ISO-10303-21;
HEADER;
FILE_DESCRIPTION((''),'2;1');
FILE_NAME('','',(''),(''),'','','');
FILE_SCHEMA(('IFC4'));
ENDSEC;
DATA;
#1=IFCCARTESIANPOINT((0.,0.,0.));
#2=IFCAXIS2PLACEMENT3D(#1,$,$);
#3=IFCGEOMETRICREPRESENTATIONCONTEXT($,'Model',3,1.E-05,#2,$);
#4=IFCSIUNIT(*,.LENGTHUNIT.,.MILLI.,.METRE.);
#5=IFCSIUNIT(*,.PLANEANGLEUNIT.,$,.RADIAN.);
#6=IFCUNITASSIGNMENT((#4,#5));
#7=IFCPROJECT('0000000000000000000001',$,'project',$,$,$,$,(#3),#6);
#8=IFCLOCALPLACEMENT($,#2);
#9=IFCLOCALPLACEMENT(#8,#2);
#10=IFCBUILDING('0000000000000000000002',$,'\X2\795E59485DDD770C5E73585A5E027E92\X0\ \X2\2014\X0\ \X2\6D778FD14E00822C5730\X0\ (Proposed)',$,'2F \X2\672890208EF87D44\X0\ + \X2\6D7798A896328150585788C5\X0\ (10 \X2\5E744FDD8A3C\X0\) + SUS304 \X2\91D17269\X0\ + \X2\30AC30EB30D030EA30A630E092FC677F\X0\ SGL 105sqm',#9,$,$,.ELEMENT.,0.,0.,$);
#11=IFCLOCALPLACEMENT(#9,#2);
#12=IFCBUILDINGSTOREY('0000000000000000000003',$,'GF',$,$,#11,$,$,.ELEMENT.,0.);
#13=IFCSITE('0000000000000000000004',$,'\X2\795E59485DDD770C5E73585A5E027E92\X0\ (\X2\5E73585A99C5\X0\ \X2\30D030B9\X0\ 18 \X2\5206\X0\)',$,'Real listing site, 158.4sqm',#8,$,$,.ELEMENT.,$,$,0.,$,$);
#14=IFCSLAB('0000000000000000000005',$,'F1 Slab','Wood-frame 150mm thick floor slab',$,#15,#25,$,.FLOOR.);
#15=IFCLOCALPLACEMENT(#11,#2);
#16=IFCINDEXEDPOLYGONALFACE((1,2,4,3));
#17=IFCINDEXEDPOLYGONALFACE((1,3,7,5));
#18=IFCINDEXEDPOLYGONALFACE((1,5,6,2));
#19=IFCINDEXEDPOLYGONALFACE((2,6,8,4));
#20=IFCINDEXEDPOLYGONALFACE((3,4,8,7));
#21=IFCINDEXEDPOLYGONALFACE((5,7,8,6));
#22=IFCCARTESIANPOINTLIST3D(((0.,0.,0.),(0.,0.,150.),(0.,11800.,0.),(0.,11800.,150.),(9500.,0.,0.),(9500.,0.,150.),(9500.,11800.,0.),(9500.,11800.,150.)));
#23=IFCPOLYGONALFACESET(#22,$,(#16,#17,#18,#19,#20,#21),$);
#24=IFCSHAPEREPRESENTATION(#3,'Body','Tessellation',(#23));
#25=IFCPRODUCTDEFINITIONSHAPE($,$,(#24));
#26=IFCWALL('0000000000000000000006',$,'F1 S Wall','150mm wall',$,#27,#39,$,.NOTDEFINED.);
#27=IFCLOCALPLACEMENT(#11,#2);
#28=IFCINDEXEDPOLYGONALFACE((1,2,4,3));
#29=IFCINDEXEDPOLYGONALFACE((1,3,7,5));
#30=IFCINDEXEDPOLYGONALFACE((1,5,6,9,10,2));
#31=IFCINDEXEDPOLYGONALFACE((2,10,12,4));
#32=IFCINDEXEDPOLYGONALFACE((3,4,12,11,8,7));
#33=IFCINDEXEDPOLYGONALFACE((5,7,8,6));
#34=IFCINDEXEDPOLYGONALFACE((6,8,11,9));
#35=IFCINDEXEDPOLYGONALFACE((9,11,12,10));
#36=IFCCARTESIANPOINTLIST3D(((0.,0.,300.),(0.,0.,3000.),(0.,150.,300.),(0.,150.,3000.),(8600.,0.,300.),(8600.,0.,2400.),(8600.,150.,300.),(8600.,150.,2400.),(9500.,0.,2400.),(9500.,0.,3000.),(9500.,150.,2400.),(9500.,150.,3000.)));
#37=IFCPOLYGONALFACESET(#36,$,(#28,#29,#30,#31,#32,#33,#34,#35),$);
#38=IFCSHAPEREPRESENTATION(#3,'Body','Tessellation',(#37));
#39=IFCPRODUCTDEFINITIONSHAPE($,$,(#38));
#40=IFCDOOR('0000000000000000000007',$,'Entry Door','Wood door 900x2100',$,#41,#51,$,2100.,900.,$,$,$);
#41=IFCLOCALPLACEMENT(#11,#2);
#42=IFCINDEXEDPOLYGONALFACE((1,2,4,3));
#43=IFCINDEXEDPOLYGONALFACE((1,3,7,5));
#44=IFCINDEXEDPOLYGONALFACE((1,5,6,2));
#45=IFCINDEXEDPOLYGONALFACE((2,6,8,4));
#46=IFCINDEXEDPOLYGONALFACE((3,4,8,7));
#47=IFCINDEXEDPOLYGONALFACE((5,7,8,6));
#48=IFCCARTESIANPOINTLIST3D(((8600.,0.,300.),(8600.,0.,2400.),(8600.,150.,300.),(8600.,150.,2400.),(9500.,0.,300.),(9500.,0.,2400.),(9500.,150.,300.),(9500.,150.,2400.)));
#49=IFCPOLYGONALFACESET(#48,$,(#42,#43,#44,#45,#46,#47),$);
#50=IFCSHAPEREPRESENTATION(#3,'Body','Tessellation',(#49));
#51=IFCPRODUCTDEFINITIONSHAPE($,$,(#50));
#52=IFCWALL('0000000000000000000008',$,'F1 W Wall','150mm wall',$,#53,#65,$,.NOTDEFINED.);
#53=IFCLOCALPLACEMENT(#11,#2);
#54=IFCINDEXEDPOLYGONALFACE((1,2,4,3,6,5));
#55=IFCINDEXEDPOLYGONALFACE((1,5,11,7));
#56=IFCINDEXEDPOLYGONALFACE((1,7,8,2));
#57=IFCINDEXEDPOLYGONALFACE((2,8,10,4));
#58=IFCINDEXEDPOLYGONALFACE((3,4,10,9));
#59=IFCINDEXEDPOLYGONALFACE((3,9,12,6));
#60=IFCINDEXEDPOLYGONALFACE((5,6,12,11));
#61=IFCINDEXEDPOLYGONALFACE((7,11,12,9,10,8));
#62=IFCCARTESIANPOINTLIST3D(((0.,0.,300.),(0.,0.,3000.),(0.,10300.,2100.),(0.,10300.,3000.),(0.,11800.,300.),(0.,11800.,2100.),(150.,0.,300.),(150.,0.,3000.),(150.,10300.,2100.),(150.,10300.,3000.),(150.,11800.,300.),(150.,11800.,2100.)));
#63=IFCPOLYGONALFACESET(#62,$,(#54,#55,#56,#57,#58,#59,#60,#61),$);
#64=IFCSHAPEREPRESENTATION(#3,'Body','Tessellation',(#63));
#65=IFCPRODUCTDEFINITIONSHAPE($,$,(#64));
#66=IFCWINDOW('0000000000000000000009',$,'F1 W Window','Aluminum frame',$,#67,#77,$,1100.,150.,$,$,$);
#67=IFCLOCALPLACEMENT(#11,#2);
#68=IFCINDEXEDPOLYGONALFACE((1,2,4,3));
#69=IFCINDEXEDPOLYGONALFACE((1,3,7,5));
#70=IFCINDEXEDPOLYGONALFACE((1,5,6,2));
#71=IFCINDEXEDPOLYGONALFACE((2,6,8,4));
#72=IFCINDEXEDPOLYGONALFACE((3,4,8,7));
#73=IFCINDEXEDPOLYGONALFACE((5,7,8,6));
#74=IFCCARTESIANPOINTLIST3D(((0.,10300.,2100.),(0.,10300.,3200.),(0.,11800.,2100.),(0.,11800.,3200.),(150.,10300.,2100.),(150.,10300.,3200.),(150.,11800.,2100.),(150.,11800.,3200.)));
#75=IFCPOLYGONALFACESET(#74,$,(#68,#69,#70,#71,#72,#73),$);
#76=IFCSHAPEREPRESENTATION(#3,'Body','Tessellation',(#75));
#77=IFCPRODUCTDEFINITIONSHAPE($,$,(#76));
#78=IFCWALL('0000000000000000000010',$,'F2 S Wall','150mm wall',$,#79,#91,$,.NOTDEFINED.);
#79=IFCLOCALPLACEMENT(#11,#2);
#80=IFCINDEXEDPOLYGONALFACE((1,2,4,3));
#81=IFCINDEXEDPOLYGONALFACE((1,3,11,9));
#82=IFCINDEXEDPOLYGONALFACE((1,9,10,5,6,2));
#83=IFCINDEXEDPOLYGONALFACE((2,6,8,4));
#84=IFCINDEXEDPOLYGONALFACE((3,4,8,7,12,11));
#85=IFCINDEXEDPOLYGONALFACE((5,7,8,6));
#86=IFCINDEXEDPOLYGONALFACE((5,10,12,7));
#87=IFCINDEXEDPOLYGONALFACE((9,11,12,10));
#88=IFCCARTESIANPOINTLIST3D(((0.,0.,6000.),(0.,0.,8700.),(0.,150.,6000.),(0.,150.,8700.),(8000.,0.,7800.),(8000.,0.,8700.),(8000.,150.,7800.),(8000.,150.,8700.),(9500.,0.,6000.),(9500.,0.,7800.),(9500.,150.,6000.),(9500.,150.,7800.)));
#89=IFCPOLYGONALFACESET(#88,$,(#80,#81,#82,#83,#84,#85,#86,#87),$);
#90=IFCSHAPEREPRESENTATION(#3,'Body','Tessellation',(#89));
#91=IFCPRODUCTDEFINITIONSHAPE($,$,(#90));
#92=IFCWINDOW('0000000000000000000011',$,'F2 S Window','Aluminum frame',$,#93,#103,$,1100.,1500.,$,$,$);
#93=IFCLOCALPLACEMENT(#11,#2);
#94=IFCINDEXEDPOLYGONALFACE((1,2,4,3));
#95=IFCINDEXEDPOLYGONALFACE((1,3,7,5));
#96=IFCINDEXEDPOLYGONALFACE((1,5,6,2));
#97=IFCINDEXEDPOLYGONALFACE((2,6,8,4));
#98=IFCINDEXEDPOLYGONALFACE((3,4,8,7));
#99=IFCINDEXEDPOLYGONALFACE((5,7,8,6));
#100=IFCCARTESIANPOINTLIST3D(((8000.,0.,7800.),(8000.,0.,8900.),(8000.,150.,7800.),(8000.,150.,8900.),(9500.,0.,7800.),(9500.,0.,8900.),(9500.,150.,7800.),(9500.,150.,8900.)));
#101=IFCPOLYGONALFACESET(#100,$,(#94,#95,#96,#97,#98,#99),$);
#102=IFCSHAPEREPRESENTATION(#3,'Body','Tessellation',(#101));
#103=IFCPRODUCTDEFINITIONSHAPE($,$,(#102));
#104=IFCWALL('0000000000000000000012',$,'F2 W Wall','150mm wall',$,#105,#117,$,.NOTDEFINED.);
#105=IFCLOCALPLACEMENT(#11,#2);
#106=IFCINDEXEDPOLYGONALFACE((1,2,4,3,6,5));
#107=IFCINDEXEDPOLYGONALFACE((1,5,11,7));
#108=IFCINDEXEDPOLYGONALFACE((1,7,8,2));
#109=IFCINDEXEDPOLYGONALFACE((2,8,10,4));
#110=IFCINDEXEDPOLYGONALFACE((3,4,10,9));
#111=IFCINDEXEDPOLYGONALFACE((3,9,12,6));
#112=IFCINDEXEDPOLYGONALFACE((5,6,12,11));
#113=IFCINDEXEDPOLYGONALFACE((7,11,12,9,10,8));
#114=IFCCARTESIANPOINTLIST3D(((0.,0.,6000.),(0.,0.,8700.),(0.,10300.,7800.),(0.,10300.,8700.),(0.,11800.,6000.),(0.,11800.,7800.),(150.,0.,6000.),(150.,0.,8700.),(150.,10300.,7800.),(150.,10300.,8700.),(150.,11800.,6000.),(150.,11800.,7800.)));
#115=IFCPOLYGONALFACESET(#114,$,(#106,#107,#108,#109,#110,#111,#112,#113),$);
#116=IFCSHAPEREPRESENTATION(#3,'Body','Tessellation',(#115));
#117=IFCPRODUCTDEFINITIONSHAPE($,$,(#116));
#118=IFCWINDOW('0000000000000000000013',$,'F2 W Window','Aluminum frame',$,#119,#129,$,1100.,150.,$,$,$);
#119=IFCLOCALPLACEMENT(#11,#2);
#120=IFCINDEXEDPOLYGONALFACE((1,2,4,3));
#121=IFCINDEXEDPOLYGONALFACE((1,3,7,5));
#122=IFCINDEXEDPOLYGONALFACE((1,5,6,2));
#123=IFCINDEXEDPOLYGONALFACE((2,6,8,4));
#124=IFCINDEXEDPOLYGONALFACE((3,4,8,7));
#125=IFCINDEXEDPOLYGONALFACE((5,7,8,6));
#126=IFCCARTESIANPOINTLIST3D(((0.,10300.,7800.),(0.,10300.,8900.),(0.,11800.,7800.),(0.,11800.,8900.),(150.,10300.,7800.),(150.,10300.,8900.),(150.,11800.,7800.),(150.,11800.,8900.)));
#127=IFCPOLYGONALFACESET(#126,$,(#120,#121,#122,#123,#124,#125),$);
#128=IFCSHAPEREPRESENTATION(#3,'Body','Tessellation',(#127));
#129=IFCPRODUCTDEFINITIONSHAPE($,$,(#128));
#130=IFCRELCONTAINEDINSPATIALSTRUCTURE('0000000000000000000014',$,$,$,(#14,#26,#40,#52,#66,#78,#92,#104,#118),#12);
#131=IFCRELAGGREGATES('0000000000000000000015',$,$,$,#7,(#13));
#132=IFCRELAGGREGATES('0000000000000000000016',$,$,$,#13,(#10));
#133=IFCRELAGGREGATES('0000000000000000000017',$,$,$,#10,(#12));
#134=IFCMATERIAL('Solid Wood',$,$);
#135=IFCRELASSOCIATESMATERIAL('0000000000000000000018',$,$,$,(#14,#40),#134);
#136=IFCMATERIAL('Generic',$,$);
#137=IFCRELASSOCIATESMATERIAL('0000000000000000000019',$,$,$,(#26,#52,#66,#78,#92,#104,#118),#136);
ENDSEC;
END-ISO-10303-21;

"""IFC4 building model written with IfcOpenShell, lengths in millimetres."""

from ifc_helpers import new_model, si_unit, frame, frame_2d, origin, place, context, project, spatial, rectangle, extrude, material, element, fill, save


model = new_model("IFC4")

# Units and contexts
model_context = context("Model", 3, precision=1e-05, world=origin())
ifc_project = project(units=[si_unit("LENGTHUNIT", "METRE", prefix="MILLI"), si_unit("PLANEANGLEUNIT", "RADIAN")], contexts=[model_context])

# Site, building, storey
site_placement = place(None, origin())
site = spatial("IfcSite", under=ifc_project, at=site_placement, Name="神奈川県平塚市纒 (平塚駅 バス 18 分)", ObjectType="Real listing site, 158.4sqm", CompositionType="ELEMENT", RefElevation=0.0)
building_placement = place(site_placement, origin())
building = spatial("IfcBuilding", under=site, at=building_placement, Name="神奈川県平塚市纒 — 海近一般地 (Proposed)", ObjectType="2F 木造軸組 + 海風防腐塗装 (10 年保証) + SUS304 金物 + ガルバリウム鋼板 SGL 105sqm", CompositionType="ELEMENT", ElevationOfRefHeight=0.0, ElevationOfTerrain=0.0)
storey_placement = place(building_placement, origin())
storey = spatial("IfcBuildingStorey", under=building, at=storey_placement, Name="GF", CompositionType="ELEMENT", Elevation=0.0)

# Slab
ifc_material_1 = material(Name="Solid Wood")
slab_1_placement = place(storey_placement, origin())
element("IfcSlab", 1, at=slab_1_placement, inside=storey, material=ifc_material_1, Name="F1 Slab", Description="Wood-frame 150mm thick floor slab", PredefinedType="FLOOR", context=model_context, shape_type="SweptSolid", body=[
    extrude(rectangle(XDim=9500.0, YDim=11800.0, at=frame_2d((4750.0, 5900.0))), origin(), (0.0, 0.0, 1.0), 150.0),
])

# Shared definitions
ifc_material_2 = material(Name="Generic")

# Wall, opening, door
wall_1_placement = place(storey_placement, frame((0.0, 0.0, 150.0)))
wall_1 = element("IfcWall", 2, at=wall_1_placement, inside=storey, material=ifc_material_2, Name="F1 S Wall", Description="150mm wall", PredefinedType="NOTDEFINED", context=model_context, shape_type="SweptSolid", body=[
    extrude(rectangle(XDim=9500.0, YDim=150.0, at=frame_2d((4750.0, 75.0))), frame((0.0, 0.0, 150.0)), (0.0, 0.0, 1.0), 2700.0),
])
opening_1_placement = place(storey_placement, frame((4300.0, 0.0, 150.0)))
opening_1 = element("IfcOpeningElement", 3, at=opening_1_placement, cuts=wall_1, PredefinedType="NOTDEFINED", context=model_context, shape_type="SweptSolid", body=[
    extrude(rectangle(XDim=900.0, YDim=150.0, at=frame_2d((450.0, 75.0))), frame((4300.0, 0.0, 150.0)), (0.0, 0.0, 1.0), 2100.0),
])
door_placement = place(storey_placement, frame((4300.0, 0.0, 150.0)))
door = element("IfcDoor", 4, at=door_placement, inside=storey, material=ifc_material_1, Name="Entry Door", Description="Wood door 900x2100", OverallHeight=2100.0, OverallWidth=900.0, context=model_context, shape_type="SweptSolid", body=[
    extrude(rectangle(XDim=900.0, YDim=150.0, at=frame_2d((450.0, 75.0))), frame((4300.0, 0.0, 150.0)), (0.0, 0.0, 1.0), 2100.0),
])
fill(opening_1, door)

# Walls, openings, windows
wall_2_placement = place(storey_placement, frame((0.0, 0.0, 150.0)))
wall_2 = element("IfcWall", 5, at=wall_2_placement, inside=storey, material=ifc_material_2, Name="F1 W Wall", Description="150mm wall", PredefinedType="NOTDEFINED", context=model_context, shape_type="SweptSolid", body=[
    extrude(rectangle(XDim=150.0, YDim=11800.0, at=frame_2d((75.0, 5900.0))), frame((0.0, 0.0, 150.0)), (0.0, 0.0, 1.0), 2700.0),
])
opening_2_placement = place(storey_placement, frame((0.0, 5150.0, 1050.0)))
opening_2 = element("IfcOpeningElement", 6, at=opening_2_placement, cuts=wall_2, PredefinedType="NOTDEFINED", context=model_context, shape_type="SweptSolid", body=[
    extrude(rectangle(XDim=150.0, YDim=1500.0, at=frame_2d((75.0, 750.0))), frame((0.0, 5150.0, 1050.0)), (0.0, 0.0, 1.0), 1100.0),
])
window_1_placement = place(storey_placement, frame((0.0, 5150.0, 1050.0)))
window_1 = element("IfcWindow", 7, at=window_1_placement, inside=storey, material=ifc_material_2, Name="F1 W Window", Description="Aluminum frame", OverallHeight=1100.0, OverallWidth=150.0, context=model_context, shape_type="SweptSolid", body=[
    extrude(rectangle(XDim=150.0, YDim=1500.0, at=frame_2d((75.0, 750.0))), frame((0.0, 5150.0, 1050.0)), (0.0, 0.0, 1.0), 1100.0),
])
fill(opening_2, window_1)
wall_3_placement = place(storey_placement, frame((0.0, 0.0, 3000.0)))
wall_3 = element("IfcWall", 8, at=wall_3_placement, inside=storey, material=ifc_material_2, Name="F2 S Wall", Description="150mm wall", PredefinedType="NOTDEFINED", context=model_context, shape_type="SweptSolid", body=[
    extrude(rectangle(XDim=9500.0, YDim=150.0, at=frame_2d((4750.0, 75.0))), frame((0.0, 0.0, 3000.0)), (0.0, 0.0, 1.0), 2700.0),
])
opening_3_placement = place(storey_placement, frame((4000.0, 0.0, 3900.0)))
opening_3 = element("IfcOpeningElement", 9, at=opening_3_placement, cuts=wall_3, PredefinedType="NOTDEFINED", context=model_context, shape_type="SweptSolid", body=[
    extrude(rectangle(XDim=1500.0, YDim=150.0, at=frame_2d((750.0, 75.0))), frame((4000.0, 0.0, 3900.0)), (0.0, 0.0, 1.0), 1100.0),
])
window_2_placement = place(storey_placement, frame((4000.0, 0.0, 3900.0)))
window_2 = element("IfcWindow", 10, at=window_2_placement, inside=storey, material=ifc_material_2, Name="F2 S Window", Description="Aluminum frame", OverallHeight=1100.0, OverallWidth=1500.0, context=model_context, shape_type="SweptSolid", body=[
    extrude(rectangle(XDim=1500.0, YDim=150.0, at=frame_2d((750.0, 75.0))), frame((4000.0, 0.0, 3900.0)), (0.0, 0.0, 1.0), 1100.0),
])
fill(opening_3, window_2)
wall_4_placement = place(storey_placement, frame((0.0, 0.0, 3000.0)))
wall_4 = element("IfcWall", 11, at=wall_4_placement, inside=storey, material=ifc_material_2, Name="F2 W Wall", Description="150mm wall", PredefinedType="NOTDEFINED", context=model_context, shape_type="SweptSolid", body=[
    extrude(rectangle(XDim=150.0, YDim=11800.0, at=frame_2d((75.0, 5900.0))), frame((0.0, 0.0, 3000.0)), (0.0, 0.0, 1.0), 2700.0),
])
opening_4_placement = place(storey_placement, frame((0.0, 5150.0, 3900.0)))
opening_4 = element("IfcOpeningElement", 12, at=opening_4_placement, cuts=wall_4, PredefinedType="NOTDEFINED", context=model_context, shape_type="SweptSolid", body=[
    extrude(rectangle(XDim=150.0, YDim=1500.0, at=frame_2d((75.0, 750.0))), frame((0.0, 5150.0, 3900.0)), (0.0, 0.0, 1.0), 1100.0),
])
window_3_placement = place(storey_placement, frame((0.0, 5150.0, 3900.0)))
window_3 = element("IfcWindow", 13, at=window_3_placement, inside=storey, material=ifc_material_2, Name="F2 W Window", Description="Aluminum frame", OverallHeight=1100.0, OverallWidth=150.0, context=model_context, shape_type="SweptSolid", body=[
    extrude(rectangle(XDim=150.0, YDim=1500.0, at=frame_2d((75.0, 750.0))), frame((0.0, 5150.0, 3900.0)), (0.0, 0.0, 1.0), 1100.0),
])
fill(opening_4, window_3)

save(model, "model.ifc")
